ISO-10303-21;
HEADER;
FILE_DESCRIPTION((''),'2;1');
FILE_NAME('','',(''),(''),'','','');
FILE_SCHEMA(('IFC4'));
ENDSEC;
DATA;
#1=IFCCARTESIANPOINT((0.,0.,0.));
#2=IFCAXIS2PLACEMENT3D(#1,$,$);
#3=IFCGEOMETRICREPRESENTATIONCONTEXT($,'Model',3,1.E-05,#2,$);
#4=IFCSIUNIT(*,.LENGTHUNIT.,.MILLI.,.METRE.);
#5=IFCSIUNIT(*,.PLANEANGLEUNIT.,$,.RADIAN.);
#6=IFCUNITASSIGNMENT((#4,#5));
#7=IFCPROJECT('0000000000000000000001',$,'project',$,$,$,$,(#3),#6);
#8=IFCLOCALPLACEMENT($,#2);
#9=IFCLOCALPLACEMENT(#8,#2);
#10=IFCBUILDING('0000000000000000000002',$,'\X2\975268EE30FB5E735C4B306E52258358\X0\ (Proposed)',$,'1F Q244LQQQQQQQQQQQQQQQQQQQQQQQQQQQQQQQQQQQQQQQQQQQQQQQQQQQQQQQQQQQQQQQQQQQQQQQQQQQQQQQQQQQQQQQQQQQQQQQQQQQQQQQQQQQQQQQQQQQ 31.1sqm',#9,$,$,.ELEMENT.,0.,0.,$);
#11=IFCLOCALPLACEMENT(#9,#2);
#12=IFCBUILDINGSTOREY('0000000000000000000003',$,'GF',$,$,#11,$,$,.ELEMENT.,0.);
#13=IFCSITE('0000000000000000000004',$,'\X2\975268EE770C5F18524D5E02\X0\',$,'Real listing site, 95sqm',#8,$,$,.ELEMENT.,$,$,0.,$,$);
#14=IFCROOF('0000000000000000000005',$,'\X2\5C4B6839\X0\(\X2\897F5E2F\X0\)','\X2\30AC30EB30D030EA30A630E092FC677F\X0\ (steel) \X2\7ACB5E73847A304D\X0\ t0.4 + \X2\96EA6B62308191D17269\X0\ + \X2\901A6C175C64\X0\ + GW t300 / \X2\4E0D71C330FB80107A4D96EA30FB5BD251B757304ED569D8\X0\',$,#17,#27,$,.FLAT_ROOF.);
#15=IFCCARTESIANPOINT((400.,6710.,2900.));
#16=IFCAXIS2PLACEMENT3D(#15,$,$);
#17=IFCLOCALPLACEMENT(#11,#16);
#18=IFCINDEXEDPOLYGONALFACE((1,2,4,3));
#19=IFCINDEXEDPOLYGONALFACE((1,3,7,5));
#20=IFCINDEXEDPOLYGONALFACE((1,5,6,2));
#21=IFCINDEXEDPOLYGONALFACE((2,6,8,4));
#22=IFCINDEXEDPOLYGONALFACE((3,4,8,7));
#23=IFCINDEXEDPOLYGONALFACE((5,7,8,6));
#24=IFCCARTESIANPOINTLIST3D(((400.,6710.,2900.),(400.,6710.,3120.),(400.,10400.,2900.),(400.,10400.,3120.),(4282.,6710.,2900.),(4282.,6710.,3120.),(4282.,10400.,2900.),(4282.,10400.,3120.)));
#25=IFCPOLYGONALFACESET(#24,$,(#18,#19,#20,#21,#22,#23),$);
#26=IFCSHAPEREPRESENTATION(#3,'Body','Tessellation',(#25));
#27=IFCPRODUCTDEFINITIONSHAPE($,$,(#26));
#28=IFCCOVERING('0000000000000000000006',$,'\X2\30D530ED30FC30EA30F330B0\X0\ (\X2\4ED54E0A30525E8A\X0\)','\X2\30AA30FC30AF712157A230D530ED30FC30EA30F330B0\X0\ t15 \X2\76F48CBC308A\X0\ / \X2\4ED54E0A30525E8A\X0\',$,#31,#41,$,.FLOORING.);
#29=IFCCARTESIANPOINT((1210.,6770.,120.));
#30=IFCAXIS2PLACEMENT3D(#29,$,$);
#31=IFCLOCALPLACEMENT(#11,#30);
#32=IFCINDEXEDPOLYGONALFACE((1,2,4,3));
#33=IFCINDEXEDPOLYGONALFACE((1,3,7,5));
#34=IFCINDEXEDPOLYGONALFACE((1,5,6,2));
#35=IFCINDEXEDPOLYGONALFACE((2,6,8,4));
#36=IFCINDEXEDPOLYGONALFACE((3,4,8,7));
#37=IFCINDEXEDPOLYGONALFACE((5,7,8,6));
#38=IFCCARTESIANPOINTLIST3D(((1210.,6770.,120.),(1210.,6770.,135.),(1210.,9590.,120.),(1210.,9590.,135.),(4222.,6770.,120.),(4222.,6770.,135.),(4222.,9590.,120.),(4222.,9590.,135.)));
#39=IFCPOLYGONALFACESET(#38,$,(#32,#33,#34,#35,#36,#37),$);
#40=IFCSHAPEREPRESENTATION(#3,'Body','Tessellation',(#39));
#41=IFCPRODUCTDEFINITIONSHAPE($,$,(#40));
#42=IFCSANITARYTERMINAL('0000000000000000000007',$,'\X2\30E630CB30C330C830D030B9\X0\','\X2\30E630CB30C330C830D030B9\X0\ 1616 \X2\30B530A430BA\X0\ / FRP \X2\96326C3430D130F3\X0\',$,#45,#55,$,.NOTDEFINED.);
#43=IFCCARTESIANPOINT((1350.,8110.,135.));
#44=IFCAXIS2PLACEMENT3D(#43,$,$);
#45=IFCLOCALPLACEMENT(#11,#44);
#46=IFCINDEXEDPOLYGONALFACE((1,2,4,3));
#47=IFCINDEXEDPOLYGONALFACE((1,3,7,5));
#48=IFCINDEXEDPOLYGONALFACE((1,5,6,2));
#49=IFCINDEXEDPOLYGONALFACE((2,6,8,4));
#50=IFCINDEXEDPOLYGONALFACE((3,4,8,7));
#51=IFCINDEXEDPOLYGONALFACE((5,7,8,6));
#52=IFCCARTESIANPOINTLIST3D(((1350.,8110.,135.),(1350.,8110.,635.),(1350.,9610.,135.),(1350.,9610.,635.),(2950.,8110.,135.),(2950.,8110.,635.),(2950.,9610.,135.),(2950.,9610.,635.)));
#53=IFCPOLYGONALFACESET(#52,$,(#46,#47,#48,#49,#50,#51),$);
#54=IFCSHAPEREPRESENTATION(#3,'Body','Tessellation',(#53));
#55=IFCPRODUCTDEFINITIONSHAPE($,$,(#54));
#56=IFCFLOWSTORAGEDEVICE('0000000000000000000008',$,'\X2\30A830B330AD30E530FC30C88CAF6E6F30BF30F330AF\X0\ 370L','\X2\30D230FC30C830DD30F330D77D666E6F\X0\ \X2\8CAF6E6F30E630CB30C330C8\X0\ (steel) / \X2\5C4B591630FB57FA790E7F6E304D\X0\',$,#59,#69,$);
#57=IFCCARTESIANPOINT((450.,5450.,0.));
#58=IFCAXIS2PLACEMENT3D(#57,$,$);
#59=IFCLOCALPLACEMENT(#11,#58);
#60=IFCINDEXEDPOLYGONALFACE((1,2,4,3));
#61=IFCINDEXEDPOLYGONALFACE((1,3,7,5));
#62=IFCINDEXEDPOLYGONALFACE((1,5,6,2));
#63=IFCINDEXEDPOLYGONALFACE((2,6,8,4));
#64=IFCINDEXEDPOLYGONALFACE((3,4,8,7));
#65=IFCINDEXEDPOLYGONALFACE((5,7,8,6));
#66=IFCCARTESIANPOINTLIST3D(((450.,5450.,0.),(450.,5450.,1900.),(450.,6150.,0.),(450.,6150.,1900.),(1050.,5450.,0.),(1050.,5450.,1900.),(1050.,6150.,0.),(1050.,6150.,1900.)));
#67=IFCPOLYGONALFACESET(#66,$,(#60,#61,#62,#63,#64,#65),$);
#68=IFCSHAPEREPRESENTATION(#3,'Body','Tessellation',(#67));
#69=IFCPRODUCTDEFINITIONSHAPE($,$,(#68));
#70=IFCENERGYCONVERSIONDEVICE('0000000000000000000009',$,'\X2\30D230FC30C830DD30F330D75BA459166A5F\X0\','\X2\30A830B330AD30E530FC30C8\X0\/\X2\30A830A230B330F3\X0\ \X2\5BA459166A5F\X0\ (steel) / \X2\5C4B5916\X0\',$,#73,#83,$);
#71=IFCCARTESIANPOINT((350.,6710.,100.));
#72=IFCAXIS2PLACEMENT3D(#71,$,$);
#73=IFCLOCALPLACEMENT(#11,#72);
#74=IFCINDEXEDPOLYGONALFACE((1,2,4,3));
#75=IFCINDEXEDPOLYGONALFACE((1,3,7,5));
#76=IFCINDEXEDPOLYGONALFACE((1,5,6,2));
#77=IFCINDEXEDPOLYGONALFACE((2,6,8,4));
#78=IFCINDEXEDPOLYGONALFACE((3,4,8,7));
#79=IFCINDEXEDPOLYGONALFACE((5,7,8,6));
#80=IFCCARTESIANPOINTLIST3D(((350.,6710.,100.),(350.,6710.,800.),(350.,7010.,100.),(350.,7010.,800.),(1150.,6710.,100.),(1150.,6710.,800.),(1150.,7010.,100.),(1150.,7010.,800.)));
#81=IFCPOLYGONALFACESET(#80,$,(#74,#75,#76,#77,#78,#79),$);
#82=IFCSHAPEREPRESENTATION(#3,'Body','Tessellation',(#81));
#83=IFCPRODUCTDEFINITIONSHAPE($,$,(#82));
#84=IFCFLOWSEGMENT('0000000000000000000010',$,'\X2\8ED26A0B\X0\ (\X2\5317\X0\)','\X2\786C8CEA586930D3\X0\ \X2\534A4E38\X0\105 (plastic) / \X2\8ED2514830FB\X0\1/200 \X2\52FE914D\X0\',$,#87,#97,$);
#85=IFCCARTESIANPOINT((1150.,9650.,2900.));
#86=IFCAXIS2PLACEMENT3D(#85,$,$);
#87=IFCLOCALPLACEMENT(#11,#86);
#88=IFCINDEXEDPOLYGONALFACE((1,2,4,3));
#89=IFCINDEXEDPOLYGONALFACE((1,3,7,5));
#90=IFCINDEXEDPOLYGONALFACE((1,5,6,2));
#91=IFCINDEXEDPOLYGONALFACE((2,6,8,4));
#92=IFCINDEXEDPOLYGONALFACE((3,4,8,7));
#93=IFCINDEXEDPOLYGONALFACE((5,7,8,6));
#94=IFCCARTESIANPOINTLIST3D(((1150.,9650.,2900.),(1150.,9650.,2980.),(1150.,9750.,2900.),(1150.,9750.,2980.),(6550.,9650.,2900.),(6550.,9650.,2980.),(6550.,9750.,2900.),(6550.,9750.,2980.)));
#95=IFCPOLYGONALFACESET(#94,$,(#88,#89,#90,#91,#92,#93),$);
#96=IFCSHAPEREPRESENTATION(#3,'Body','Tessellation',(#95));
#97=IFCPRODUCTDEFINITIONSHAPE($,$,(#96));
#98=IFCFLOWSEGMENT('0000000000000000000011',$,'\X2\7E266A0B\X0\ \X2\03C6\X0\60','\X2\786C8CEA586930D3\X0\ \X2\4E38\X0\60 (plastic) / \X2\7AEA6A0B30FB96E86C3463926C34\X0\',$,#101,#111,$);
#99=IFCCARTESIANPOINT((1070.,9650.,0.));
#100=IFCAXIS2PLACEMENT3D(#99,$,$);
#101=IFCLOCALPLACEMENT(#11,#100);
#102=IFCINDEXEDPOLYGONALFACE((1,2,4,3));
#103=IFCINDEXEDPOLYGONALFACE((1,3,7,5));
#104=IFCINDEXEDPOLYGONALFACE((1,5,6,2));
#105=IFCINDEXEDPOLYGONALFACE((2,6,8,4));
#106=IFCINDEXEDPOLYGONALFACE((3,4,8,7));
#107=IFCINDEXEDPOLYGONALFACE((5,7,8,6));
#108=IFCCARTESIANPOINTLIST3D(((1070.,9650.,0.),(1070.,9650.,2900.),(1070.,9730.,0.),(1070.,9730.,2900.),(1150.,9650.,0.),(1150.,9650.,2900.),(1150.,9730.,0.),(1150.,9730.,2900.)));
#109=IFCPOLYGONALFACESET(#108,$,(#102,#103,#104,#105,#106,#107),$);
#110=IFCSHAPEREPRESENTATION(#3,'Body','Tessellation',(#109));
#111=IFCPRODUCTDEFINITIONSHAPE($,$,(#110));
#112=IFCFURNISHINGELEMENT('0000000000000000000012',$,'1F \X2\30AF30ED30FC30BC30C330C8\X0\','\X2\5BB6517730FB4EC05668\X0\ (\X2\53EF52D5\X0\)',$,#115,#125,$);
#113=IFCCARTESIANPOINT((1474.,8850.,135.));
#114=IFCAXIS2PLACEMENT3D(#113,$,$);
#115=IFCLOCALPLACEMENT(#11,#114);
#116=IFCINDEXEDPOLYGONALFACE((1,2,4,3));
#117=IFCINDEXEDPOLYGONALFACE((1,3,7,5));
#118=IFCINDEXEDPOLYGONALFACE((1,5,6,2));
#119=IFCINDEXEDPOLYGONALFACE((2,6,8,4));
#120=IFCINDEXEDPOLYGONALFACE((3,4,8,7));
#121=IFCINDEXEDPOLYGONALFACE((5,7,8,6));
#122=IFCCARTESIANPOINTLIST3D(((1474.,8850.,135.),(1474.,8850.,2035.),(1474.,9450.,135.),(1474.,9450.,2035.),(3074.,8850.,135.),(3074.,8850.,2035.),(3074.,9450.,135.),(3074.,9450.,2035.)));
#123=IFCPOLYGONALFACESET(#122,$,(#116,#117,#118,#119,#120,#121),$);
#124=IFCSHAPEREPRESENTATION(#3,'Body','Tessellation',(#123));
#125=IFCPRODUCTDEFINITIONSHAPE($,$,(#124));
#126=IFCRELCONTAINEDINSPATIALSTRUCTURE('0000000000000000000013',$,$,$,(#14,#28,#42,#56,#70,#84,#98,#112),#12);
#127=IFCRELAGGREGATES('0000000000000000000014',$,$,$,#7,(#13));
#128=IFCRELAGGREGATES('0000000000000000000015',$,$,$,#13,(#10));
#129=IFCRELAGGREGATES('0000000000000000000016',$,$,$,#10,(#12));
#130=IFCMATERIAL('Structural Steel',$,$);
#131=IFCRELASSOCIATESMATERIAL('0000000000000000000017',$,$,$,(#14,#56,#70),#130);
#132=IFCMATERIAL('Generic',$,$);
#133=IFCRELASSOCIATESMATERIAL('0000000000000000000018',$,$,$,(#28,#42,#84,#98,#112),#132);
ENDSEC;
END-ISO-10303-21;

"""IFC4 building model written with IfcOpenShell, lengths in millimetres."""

from ifc_helpers import new_model, si_unit, frame, frame_2d, origin, place, context, project, spatial, rectangle, extrude, material, element, save


model = new_model("IFC4")

# Units and contexts
model_context = context("Model", 3, precision=1e-05, world=origin())
ifc_project = project(units=[si_unit("LENGTHUNIT", "METRE", prefix="MILLI"), si_unit("PLANEANGLEUNIT", "RADIAN")], contexts=[model_context])

# Site, building, storey
site_placement = place(None, origin())
site = spatial("IfcSite", under=ifc_project, at=site_placement, Name="青森県弘前市", ObjectType="Real listing site, 95sqm", CompositionType="ELEMENT", RefElevation=0.0)
building_placement = place(site_placement, origin())
building = spatial("IfcBuilding", under=site, at=building_placement, Name="青森・平屋の別荘 (Proposed)", ObjectType="1F Q244LQQQQQQQQQQQQQQQQQQQQQQQQQQQQQQQQQQQQQQQQQQQQQQQQQQQQQQQQQQQQQQQQQQQQQQQQQQQQQQQQQQQQQQQQQQQQQQQQQQQQQQQQQQQQQQQQQQQ 31.1sqm", CompositionType="ELEMENT", ElevationOfRefHeight=0.0, ElevationOfTerrain=0.0)
storey_placement = place(building_placement, origin())
storey = spatial("IfcBuildingStorey", under=building, at=storey_placement, Name="GF", CompositionType="ELEMENT", Elevation=0.0)

# Roof
ifc_material_1 = material(Name="Structural Steel")
roof_placement = place(storey_placement, frame((400.0, 6710.0, 2900.0)))
element("IfcRoof", 1, at=roof_placement, inside=storey, material=ifc_material_1, Name="屋根(西帯)", Description="ガルバリウム鋼板 (steel) 立平葺き t0.4 + 雪止め金物 + 通気層 + GW t300 / 不燃・耐積雪・寒冷地仕様", PredefinedType="FLAT_ROOF", context=model_context, shape_type="SweptSolid", body=[
    extrude(rectangle(XDim=3882.0, YDim=3690.0, at=frame_2d((1941.0, 1845.0))), frame((400.0, 6710.0, 2900.0)), (0.0, 0.0, 1.0), 220.0),
])

# Covering
ifc_material_2 = material(Name="Generic")
covering_placement = place(storey_placement, frame((1210.0, 6770.0, 120.0)))
element("IfcCovering", 2, at=covering_placement, inside=storey, material=ifc_material_2, Name="フローリング (仕上げ床)", Description="オーク無垢フローリング t15 直貼り / 仕上げ床", PredefinedType="FLOORING", context=model_context, shape_type="SweptSolid", body=[
    extrude(rectangle(XDim=3012.0, YDim=2820.0, at=frame_2d((1506.0, 1410.0))), frame((1210.0, 6770.0, 120.0)), (0.0, 0.0, 1.0), 15.0),
])

# Sanitary terminal
sanitary_terminal_placement = place(storey_placement, frame((1350.0, 8110.0, 135.0)))
element("IfcSanitaryTerminal", 3, at=sanitary_terminal_placement, inside=storey, material=ifc_material_2, Name="ユニットバス", Description="ユニットバス 1616 サイズ / FRP 防水パン", PredefinedType="NOTDEFINED", context=model_context, shape_type="SweptSolid", body=[
    extrude(rectangle(XDim=1600.0, YDim=1500.0, at=frame_2d((800.0, 750.0))), frame((1350.0, 8110.0, 135.0)), (0.0, 0.0, 1.0), 500.0),
])

# Flow storage device
flow_storage_device_placement = place(storey_placement, frame((450.0, 5450.0, 0.0)))
element("IfcFlowStorageDevice", 4, at=flow_storage_device_placement, inside=storey, material=ifc_material_1, Name="エコキュート貯湯タンク 370L", Description="ヒートポンプ給湯 貯湯ユニット (steel) / 屋外・基礎置き", context=model_context, shape_type="SweptSolid", body=[
    extrude(rectangle(XDim=600.0, YDim=700.0, at=frame_2d((300.0, 350.0))), frame((450.0, 5450.0, 0.0)), (0.0, 0.0, 1.0), 1900.0),
])

# Energy conversion device
energy_conversion_device_placement = place(storey_placement, frame((350.0, 6710.0, 100.0)))
element("IfcEnergyConversionDevice", 5, at=energy_conversion_device_placement, inside=storey, material=ifc_material_1, Name="ヒートポンプ室外機", Description="エコキュート/エアコン 室外機 (steel) / 屋外", context=model_context, shape_type="SweptSolid", body=[
    extrude(rectangle(XDim=800.0, YDim=300.0, at=frame_2d((400.0, 150.0))), frame((350.0, 6710.0, 100.0)), (0.0, 0.0, 1.0), 700.0),
])

# Flow segments
flow_segment_1_placement = place(storey_placement, frame((1150.0, 9650.0, 2900.0)))
element("IfcFlowSegment", 6, at=flow_segment_1_placement, inside=storey, material=ifc_material_2, Name="軒樋 (北)", Description="硬質塩ビ 半丸105 (plastic) / 軒先・1/200 勾配", context=model_context, shape_type="SweptSolid", body=[
    extrude(rectangle(XDim=5400.0, YDim=100.0, at=frame_2d((2700.0, 50.0))), frame((1150.0, 9650.0, 2900.0)), (0.0, 0.0, 1.0), 80.0),
])
flow_segment_2_placement = place(storey_placement, frame((1070.0, 9650.0, 0.0)))
element("IfcFlowSegment", 7, at=flow_segment_2_placement, inside=storey, material=ifc_material_2, Name="縦樋 φ60", Description="硬質塩ビ 丸60 (plastic) / 竪樋・雨水排水", context=model_context, shape_type="SweptSolid", body=[
    extrude(rectangle(XDim=80.0, YDim=80.0, at=frame_2d((40.0, 40.0))), frame((1070.0, 9650.0, 0.0)), (0.0, 0.0, 1.0), 2900.0),
])

# Furnishing element
furnishing_placement = place(storey_placement, frame((1474.0, 8850.0, 135.0)))
element("IfcFurnishingElement", 8, at=furnishing_placement, inside=storey, material=ifc_material_2, Name="1F クローゼット", Description="家具・什器 (可動)", context=model_context, shape_type="SweptSolid", body=[
    extrude(rectangle(XDim=1600.0, YDim=600.0, at=frame_2d((800.0, 300.0))), frame((1474.0, 8850.0, 135.0)), (0.0, 0.0, 1.0), 1900.0),
])

save(model, "model.ifc")
